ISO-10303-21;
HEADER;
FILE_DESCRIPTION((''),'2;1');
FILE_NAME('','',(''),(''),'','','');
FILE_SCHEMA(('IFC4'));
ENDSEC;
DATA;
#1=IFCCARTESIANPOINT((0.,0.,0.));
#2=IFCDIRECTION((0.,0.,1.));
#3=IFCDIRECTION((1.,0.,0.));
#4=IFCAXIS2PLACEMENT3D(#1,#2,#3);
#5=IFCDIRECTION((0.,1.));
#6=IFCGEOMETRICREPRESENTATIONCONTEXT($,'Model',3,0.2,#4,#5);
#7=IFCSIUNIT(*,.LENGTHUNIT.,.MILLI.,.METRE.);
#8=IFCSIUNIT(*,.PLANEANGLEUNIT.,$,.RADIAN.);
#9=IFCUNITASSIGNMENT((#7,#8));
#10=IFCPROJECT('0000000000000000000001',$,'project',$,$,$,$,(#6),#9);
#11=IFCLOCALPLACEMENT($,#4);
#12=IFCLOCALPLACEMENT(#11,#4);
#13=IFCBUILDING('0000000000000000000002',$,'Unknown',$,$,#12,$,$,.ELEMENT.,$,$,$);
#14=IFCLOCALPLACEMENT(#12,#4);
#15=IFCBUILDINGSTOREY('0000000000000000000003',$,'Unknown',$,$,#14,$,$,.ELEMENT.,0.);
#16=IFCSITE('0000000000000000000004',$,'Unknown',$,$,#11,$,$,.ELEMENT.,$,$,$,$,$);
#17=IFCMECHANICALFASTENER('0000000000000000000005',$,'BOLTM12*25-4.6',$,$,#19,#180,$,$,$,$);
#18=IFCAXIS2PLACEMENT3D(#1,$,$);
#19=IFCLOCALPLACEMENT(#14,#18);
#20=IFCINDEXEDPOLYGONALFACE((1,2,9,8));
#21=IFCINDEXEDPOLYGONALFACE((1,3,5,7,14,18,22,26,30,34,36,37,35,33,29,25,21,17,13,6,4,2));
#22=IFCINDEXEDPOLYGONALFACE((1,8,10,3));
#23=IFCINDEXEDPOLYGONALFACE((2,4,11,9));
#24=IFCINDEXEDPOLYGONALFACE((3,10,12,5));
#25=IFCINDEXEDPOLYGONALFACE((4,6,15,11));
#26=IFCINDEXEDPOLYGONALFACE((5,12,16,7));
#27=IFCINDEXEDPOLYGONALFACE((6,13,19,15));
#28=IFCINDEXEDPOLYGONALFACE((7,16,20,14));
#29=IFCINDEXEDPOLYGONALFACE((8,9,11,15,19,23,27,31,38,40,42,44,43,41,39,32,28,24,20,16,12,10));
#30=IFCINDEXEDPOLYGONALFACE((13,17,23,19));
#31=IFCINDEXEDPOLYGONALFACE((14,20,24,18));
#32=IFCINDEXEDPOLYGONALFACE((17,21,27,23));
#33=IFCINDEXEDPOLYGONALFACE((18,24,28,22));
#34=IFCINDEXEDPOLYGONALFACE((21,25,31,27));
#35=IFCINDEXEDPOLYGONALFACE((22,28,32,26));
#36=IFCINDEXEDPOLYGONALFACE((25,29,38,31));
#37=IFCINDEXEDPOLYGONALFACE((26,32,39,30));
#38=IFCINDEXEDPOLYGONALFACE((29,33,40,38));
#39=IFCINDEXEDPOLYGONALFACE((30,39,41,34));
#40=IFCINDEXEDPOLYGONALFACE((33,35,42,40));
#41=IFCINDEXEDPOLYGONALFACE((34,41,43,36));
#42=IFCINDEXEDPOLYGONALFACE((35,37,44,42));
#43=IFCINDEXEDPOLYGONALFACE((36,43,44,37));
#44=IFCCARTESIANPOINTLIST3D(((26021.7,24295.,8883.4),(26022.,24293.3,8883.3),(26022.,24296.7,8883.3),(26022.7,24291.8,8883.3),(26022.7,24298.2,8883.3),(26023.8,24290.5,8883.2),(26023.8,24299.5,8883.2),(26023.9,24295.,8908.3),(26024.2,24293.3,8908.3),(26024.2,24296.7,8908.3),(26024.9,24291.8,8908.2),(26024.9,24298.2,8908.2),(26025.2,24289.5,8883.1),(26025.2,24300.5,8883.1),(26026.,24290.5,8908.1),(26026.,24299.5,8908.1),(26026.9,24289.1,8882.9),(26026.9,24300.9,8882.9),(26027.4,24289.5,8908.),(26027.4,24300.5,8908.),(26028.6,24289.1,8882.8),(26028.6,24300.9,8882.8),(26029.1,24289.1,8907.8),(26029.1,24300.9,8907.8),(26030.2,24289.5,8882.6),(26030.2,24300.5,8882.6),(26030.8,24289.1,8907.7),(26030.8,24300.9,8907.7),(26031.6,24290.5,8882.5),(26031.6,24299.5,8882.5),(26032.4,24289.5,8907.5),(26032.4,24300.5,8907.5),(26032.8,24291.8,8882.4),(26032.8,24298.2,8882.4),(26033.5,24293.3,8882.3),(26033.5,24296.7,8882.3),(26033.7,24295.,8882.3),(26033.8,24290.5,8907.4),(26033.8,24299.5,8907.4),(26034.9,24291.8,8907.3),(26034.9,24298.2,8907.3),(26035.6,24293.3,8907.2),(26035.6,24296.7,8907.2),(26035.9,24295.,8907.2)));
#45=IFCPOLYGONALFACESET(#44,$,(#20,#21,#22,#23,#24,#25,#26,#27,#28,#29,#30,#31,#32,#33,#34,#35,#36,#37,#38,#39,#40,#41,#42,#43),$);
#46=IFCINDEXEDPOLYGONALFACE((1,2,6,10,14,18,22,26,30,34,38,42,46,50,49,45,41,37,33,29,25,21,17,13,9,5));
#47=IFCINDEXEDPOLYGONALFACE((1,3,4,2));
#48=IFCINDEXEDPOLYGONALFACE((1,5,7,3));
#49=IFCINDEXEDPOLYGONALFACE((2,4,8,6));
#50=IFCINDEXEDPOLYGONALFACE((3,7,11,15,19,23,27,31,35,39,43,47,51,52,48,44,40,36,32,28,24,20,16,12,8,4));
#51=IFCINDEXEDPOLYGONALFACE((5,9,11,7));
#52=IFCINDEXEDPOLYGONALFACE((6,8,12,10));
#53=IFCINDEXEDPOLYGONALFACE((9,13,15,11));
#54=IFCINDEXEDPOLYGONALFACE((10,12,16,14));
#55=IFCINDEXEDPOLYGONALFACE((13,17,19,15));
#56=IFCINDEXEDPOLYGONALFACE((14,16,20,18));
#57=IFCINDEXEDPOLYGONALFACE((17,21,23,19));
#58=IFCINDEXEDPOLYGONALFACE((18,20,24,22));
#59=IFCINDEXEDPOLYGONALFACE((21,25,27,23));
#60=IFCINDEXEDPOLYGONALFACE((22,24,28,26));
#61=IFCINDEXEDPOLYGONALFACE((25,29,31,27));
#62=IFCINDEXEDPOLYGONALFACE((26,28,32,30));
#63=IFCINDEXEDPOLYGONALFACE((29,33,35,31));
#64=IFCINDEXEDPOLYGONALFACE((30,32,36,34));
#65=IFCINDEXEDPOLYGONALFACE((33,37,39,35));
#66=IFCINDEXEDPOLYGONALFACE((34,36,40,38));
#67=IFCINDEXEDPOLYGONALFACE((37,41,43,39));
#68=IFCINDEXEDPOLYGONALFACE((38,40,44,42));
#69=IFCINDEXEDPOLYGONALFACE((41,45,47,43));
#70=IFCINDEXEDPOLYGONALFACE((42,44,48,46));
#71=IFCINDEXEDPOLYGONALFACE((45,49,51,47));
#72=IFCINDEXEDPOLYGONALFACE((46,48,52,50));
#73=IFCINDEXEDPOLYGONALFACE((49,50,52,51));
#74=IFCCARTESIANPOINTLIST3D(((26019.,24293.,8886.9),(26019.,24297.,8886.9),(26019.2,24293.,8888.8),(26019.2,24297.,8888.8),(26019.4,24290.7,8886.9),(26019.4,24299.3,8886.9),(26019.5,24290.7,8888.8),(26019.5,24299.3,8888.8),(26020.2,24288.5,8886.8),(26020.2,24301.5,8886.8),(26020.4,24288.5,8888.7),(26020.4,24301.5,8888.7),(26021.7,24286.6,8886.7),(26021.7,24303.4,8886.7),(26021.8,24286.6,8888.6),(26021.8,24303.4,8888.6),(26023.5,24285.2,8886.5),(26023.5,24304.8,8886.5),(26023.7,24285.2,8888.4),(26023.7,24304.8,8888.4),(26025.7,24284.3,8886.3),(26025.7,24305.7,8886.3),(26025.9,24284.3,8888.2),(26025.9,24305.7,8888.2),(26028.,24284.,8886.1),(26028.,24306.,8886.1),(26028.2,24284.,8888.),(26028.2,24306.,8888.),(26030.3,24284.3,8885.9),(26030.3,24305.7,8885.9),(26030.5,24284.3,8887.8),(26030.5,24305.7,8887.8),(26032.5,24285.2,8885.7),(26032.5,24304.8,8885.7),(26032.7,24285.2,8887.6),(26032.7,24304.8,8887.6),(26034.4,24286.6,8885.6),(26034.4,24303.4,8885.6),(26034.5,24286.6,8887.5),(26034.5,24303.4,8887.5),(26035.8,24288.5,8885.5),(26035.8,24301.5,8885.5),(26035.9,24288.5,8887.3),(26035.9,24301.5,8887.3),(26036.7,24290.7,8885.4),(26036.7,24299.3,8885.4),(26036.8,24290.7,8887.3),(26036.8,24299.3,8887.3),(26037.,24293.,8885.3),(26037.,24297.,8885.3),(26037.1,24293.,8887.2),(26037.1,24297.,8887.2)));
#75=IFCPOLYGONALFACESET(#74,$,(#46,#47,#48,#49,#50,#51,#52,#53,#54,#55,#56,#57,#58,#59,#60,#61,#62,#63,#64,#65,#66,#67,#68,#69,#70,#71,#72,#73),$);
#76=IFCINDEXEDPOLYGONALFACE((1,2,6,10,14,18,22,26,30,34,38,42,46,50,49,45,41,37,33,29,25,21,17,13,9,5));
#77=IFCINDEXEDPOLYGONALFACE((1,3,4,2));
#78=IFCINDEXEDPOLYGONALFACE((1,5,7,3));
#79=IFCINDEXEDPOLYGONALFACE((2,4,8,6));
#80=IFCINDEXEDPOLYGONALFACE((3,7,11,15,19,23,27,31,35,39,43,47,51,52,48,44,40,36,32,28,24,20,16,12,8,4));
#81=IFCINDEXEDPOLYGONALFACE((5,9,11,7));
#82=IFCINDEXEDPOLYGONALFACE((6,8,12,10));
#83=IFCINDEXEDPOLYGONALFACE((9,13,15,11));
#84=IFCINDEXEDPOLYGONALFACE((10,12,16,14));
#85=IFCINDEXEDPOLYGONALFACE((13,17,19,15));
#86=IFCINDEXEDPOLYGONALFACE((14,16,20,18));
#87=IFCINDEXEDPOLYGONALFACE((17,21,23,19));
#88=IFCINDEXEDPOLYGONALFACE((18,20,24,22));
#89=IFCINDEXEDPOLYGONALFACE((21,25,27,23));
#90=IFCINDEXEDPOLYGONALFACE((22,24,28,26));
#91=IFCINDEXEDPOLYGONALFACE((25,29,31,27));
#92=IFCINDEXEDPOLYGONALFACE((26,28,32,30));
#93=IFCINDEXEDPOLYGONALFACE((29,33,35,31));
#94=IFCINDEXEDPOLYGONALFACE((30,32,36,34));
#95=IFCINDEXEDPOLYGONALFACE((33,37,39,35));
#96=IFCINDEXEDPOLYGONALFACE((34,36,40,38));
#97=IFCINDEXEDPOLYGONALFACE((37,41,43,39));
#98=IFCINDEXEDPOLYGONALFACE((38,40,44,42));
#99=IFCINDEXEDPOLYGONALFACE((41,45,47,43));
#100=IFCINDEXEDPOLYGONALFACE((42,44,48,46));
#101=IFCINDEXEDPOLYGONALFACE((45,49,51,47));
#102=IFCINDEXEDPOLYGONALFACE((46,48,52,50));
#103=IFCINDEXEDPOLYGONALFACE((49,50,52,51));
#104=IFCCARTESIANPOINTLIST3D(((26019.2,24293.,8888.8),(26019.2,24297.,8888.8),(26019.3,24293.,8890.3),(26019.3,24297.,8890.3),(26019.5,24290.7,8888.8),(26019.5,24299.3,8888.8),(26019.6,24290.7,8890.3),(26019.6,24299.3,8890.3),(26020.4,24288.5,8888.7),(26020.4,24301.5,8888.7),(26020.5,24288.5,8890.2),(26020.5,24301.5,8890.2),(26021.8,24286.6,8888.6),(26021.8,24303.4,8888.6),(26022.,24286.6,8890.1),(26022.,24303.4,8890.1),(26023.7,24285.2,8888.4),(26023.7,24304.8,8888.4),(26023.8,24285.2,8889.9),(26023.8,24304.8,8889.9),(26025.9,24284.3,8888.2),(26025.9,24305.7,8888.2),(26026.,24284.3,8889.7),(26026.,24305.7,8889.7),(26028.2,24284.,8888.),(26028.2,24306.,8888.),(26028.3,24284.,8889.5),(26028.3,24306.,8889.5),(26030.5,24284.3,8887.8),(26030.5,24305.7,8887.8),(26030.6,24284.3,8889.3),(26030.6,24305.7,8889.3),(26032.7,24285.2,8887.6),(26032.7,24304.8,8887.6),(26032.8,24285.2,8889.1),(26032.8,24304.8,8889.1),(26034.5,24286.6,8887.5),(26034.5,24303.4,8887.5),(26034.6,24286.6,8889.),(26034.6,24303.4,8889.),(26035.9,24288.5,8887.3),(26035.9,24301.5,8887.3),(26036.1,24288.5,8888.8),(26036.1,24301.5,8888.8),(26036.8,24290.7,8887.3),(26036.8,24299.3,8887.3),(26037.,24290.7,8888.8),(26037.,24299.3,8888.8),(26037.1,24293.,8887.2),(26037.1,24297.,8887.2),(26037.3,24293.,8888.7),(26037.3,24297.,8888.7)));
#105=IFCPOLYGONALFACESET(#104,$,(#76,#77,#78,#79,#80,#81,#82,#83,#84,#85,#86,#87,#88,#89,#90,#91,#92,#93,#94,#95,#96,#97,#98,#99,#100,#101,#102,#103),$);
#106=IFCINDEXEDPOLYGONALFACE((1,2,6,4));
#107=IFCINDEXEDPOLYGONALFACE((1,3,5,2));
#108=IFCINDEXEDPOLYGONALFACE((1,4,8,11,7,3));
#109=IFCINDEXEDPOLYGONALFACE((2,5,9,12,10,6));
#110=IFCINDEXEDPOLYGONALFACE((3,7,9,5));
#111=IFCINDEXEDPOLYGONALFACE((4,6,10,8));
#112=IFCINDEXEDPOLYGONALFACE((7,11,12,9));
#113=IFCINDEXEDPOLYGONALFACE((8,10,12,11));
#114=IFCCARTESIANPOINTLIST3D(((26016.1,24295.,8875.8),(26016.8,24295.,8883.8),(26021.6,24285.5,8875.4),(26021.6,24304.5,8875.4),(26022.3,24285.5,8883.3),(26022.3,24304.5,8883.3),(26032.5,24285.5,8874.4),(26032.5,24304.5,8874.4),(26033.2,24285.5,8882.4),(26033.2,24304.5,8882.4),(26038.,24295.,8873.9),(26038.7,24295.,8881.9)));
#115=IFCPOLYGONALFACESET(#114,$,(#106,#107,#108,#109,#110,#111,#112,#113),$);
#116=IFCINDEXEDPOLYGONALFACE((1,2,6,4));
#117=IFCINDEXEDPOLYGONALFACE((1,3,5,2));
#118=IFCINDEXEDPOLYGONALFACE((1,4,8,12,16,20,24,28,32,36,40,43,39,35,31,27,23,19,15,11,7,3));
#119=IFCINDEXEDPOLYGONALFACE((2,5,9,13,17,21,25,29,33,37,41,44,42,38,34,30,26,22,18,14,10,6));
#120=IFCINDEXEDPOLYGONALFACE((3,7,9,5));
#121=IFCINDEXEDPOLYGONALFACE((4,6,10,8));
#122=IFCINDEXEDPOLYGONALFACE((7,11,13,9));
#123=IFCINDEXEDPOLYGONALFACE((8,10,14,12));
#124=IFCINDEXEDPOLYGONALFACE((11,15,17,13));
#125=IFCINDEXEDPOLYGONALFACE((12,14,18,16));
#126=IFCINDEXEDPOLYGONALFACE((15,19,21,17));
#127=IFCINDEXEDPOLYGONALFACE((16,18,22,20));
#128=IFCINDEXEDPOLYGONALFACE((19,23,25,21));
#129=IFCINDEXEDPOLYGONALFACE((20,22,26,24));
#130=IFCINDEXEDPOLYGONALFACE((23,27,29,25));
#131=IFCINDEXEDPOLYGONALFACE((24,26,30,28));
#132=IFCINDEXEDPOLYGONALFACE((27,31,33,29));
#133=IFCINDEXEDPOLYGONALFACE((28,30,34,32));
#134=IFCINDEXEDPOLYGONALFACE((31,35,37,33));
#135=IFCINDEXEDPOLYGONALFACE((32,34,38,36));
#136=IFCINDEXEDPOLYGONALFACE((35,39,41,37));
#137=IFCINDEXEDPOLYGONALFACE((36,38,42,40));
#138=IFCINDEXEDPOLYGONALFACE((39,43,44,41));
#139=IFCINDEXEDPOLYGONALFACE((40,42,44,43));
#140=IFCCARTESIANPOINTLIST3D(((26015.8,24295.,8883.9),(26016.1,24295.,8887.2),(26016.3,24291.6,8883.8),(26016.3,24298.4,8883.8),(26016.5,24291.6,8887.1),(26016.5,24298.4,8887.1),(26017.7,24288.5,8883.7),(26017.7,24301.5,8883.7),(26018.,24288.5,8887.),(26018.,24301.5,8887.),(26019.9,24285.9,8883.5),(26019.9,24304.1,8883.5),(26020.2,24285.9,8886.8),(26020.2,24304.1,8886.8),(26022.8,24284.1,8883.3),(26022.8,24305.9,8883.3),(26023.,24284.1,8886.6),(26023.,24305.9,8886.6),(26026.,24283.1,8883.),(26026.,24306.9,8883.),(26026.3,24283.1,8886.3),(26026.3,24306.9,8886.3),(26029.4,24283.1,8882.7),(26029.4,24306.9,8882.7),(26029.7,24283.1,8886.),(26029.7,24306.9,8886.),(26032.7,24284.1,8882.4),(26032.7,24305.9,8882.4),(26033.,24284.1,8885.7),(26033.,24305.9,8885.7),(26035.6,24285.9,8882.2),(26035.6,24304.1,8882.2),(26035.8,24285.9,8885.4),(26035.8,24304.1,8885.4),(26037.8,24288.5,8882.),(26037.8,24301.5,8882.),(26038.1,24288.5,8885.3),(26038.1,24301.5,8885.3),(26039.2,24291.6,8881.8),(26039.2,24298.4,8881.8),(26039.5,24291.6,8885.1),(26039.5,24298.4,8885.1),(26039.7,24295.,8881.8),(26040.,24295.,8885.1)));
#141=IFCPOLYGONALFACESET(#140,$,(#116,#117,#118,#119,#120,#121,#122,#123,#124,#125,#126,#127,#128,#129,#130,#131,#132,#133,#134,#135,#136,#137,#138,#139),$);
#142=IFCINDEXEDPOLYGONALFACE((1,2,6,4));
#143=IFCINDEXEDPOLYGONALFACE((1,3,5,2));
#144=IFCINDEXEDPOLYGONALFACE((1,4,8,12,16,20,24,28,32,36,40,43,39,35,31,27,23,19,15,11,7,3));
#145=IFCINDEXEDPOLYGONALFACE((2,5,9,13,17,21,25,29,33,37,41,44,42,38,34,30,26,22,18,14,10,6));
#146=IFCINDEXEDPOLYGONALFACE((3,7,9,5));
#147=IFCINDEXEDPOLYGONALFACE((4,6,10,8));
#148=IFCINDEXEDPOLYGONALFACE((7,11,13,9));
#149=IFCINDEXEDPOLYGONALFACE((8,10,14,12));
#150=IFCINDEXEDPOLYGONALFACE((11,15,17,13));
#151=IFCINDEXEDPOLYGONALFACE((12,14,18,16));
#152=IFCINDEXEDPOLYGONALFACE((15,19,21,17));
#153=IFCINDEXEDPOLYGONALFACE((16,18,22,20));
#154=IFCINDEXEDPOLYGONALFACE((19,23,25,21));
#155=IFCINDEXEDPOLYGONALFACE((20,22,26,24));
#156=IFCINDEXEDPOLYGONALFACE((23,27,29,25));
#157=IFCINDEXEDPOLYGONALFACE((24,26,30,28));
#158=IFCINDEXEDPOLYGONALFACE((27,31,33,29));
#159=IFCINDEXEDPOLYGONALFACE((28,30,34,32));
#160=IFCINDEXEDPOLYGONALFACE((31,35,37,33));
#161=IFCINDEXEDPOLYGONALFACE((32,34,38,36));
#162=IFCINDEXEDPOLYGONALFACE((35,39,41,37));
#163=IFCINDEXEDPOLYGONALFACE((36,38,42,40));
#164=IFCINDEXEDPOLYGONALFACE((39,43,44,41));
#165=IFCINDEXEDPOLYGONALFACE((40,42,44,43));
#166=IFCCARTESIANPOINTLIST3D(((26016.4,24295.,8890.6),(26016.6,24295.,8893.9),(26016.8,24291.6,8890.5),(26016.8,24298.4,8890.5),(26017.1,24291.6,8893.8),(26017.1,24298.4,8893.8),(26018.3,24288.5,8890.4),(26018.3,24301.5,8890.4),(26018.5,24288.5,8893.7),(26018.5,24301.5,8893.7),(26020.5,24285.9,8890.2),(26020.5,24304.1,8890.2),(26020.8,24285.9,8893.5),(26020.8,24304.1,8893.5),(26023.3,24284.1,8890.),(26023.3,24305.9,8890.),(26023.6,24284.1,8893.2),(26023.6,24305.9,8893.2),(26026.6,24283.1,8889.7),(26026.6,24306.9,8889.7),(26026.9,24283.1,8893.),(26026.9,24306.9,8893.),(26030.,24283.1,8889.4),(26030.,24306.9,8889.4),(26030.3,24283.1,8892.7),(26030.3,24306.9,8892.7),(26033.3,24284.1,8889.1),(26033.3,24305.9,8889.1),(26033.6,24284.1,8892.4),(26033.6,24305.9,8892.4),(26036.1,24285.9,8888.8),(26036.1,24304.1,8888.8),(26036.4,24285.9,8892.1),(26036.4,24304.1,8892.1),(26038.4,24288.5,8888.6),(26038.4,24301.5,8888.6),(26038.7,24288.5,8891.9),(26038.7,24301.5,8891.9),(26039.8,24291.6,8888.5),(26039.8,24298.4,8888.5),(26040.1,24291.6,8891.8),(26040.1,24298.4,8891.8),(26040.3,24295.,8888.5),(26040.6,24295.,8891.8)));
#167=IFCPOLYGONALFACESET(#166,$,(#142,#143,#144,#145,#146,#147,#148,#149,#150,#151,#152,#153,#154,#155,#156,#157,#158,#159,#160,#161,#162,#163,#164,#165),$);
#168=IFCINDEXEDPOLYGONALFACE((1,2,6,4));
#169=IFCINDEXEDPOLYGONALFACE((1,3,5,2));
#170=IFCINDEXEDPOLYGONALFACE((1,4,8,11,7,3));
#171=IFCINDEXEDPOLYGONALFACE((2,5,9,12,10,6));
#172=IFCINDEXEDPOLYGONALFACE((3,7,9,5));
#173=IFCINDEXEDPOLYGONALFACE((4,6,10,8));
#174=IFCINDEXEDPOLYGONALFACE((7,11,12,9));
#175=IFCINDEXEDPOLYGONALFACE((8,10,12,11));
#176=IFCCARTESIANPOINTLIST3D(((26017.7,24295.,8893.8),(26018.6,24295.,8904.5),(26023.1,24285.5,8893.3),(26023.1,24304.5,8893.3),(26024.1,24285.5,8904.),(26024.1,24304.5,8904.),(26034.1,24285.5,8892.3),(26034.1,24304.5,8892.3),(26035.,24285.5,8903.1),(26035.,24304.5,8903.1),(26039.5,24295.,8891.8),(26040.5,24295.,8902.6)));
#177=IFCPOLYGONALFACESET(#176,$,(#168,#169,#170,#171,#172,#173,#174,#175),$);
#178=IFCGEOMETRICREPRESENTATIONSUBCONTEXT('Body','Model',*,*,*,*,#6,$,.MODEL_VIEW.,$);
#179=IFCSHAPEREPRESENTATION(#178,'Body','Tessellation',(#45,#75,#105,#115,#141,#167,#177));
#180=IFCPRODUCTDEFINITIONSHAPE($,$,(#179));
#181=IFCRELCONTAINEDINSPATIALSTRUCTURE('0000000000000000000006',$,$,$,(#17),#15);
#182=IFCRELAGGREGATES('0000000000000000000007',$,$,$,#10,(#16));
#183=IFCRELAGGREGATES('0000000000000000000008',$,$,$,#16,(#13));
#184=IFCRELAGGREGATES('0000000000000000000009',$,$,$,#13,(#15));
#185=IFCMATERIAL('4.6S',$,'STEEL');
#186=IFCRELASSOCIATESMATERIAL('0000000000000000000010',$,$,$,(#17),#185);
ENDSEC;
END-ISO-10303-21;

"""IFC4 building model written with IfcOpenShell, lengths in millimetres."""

from ifc_helpers import new_model, si_unit, direction, frame, origin_with_axes, place, context, subcontext, project, spatial, line, arc, indexed_curve, outline, extrude, source, transform, mapped, material, element, save


model = new_model("IFC4")

# Units and contexts
model_context = context("Model", 3, precision=0.2, world=origin_with_axes(), true_north=direction((0.0, 1.0)))
body_context = subcontext(model_context, "Body", "Model", "MODEL_VIEW")
ifc_project = project(units=[si_unit("LENGTHUNIT", "METRE", prefix="MILLI"), si_unit("PLANEANGLEUNIT", "RADIAN")], contexts=[model_context])

# Site, building, storey
site_placement = place(None, origin_with_axes())
site = spatial("IfcSite", under=ifc_project, at=site_placement, Name="Unknown", CompositionType="ELEMENT")
building_placement = place(site_placement, origin_with_axes())
building = spatial("IfcBuilding", under=site, at=building_placement, Name="Unknown", CompositionType="ELEMENT")
storey_placement = place(building_placement, origin_with_axes())
storey = spatial("IfcBuildingStorey", under=building, at=storey_placement, Name="Unknown", CompositionType="ELEMENT", Elevation=0.0)

# Mechanical fastener
ifc_material_1 = material(Name="4.6S", Category="STEEL")
shared_shape_1 = source(origin_with_axes(), body_context, "Body", "SweptSolid", [
    extrude(outline(indexed_curve([(6.0, 0.0), (0.0, 6.0), (-6.0, 0.0), (0.0, -6.0)], segments=[arc(1, 2, 3), arc(3, 4, 1)])), frame((0.0, 0.0, 4.8), z_axis=(0.0, 0.0, -1.0), x_axis=(0.0, 1.0, 0.0)), (0.0, 0.0, 1.0), 25.0),
    extrude(outline(indexed_curve([(0.0, 11.0), (6.4, 8.4), (9.0, 2.0), (9.0, -2.0), (6.4, -8.4), (0.0, -11.0), (-0.8, -11.0), (-9.0, -2.0), (-9.0, 2.0), (-6.4, 8.4)], segments=[arc(1, 2, 3), line(3, 4), arc(4, 5, 6), arc(6, 7, 8), line(8, 9), arc(9, 10, 1)])), frame((0.0, 0.0, 1.5), z_axis=(0.0, 0.0, -1.0), x_axis=(0.0, 1.0, 0.0)), (0.0, 0.0, 1.0), 1.9),
    extrude(outline(indexed_curve([(0.0, 11.0), (6.4, 8.4), (9.0, 2.0), (9.0, -2.0), (6.4, -8.4), (0.0, -11.0), (-0.8, -11.0), (-9.0, -2.0), (-9.0, 2.0), (-6.4, 8.4)], segments=[arc(1, 2, 3), line(3, 4), arc(4, 5, 6), arc(6, 7, 8), line(8, 9), arc(9, 10, 1)])), frame((0.0, 0.0, -0.4), z_axis=(0.0, 0.0, -1.0), x_axis=(0.0, 1.0, 0.0)), (0.0, 0.0, 1.0), 1.5),
    extrude(outline(indexed_curve([(11.0, 0.0), (5.5, 9.5), (-5.5, 9.5), (-11.0, 0.0), (-5.5, -9.5), (5.5, -9.5)], segments=[line(1, 2, 3, 4, 5, 6, 1)])), frame((0.0, 0.0, 12.8), z_axis=(0.0, 0.0, -1.0), x_axis=(0.0, 1.0, 0.0)), (0.0, 0.0, 1.0), 8.0),
    extrude(outline(indexed_curve([(12.0, 0.0), (0.0, 12.0), (-12.0, 0.0), (0.0, -12.0)], segments=[arc(1, 2, 3), arc(3, 4, 1)])), frame((0.0, 0.0, 4.8), z_axis=(0.0, 0.0, -1.0), x_axis=(0.0, 1.0, 0.0)), (0.0, 0.0, 1.0), 3.3),
    extrude(outline(indexed_curve([(12.0, 0.0), (0.0, 12.0), (-12.0, 0.0), (0.0, -12.0)], segments=[arc(1, 2, 3), arc(3, 4, 1)])), frame((0.0, 0.0, -1.9), z_axis=(0.0, 0.0, -1.0), x_axis=(0.0, 1.0, 0.0)), (0.0, 0.0, 1.0), 3.3),
    extrude(outline(indexed_curve([(11.0, 0.0), (5.5, 9.5), (-5.5, 9.5), (-11.0, 0.0), (-5.5, -9.5), (5.5, -9.5)], segments=[line(1, 2, 3, 4, 5, 6, 1)])), frame((0.0, 0.0, -5.2), z_axis=(0.0, 0.0, -1.0), x_axis=(0.0, 1.0, 0.0)), (0.0, 0.0, 1.0), 10.8),
])
for number, where, z_axis, x_axis, name in (
    (1, (26028.1, 24295.0, 8887.6), (-0.08716, 0.0, -0.996194), (0.0, 1.0, 0.0), "BOLTM12*25-4.6"),
):
    element("IfcMechanicalFastener", number, at=place(storey_placement, frame(where, z_axis=z_axis, x_axis=x_axis)), inside=storey, material=ifc_material_1, Name=name, context=body_context, shape_type="MappedRepresentation", body=[
        mapped(shared_shape_1, transform((0.0, 0.0, 0.0))),
    ])

save(model, "model.ifc")
